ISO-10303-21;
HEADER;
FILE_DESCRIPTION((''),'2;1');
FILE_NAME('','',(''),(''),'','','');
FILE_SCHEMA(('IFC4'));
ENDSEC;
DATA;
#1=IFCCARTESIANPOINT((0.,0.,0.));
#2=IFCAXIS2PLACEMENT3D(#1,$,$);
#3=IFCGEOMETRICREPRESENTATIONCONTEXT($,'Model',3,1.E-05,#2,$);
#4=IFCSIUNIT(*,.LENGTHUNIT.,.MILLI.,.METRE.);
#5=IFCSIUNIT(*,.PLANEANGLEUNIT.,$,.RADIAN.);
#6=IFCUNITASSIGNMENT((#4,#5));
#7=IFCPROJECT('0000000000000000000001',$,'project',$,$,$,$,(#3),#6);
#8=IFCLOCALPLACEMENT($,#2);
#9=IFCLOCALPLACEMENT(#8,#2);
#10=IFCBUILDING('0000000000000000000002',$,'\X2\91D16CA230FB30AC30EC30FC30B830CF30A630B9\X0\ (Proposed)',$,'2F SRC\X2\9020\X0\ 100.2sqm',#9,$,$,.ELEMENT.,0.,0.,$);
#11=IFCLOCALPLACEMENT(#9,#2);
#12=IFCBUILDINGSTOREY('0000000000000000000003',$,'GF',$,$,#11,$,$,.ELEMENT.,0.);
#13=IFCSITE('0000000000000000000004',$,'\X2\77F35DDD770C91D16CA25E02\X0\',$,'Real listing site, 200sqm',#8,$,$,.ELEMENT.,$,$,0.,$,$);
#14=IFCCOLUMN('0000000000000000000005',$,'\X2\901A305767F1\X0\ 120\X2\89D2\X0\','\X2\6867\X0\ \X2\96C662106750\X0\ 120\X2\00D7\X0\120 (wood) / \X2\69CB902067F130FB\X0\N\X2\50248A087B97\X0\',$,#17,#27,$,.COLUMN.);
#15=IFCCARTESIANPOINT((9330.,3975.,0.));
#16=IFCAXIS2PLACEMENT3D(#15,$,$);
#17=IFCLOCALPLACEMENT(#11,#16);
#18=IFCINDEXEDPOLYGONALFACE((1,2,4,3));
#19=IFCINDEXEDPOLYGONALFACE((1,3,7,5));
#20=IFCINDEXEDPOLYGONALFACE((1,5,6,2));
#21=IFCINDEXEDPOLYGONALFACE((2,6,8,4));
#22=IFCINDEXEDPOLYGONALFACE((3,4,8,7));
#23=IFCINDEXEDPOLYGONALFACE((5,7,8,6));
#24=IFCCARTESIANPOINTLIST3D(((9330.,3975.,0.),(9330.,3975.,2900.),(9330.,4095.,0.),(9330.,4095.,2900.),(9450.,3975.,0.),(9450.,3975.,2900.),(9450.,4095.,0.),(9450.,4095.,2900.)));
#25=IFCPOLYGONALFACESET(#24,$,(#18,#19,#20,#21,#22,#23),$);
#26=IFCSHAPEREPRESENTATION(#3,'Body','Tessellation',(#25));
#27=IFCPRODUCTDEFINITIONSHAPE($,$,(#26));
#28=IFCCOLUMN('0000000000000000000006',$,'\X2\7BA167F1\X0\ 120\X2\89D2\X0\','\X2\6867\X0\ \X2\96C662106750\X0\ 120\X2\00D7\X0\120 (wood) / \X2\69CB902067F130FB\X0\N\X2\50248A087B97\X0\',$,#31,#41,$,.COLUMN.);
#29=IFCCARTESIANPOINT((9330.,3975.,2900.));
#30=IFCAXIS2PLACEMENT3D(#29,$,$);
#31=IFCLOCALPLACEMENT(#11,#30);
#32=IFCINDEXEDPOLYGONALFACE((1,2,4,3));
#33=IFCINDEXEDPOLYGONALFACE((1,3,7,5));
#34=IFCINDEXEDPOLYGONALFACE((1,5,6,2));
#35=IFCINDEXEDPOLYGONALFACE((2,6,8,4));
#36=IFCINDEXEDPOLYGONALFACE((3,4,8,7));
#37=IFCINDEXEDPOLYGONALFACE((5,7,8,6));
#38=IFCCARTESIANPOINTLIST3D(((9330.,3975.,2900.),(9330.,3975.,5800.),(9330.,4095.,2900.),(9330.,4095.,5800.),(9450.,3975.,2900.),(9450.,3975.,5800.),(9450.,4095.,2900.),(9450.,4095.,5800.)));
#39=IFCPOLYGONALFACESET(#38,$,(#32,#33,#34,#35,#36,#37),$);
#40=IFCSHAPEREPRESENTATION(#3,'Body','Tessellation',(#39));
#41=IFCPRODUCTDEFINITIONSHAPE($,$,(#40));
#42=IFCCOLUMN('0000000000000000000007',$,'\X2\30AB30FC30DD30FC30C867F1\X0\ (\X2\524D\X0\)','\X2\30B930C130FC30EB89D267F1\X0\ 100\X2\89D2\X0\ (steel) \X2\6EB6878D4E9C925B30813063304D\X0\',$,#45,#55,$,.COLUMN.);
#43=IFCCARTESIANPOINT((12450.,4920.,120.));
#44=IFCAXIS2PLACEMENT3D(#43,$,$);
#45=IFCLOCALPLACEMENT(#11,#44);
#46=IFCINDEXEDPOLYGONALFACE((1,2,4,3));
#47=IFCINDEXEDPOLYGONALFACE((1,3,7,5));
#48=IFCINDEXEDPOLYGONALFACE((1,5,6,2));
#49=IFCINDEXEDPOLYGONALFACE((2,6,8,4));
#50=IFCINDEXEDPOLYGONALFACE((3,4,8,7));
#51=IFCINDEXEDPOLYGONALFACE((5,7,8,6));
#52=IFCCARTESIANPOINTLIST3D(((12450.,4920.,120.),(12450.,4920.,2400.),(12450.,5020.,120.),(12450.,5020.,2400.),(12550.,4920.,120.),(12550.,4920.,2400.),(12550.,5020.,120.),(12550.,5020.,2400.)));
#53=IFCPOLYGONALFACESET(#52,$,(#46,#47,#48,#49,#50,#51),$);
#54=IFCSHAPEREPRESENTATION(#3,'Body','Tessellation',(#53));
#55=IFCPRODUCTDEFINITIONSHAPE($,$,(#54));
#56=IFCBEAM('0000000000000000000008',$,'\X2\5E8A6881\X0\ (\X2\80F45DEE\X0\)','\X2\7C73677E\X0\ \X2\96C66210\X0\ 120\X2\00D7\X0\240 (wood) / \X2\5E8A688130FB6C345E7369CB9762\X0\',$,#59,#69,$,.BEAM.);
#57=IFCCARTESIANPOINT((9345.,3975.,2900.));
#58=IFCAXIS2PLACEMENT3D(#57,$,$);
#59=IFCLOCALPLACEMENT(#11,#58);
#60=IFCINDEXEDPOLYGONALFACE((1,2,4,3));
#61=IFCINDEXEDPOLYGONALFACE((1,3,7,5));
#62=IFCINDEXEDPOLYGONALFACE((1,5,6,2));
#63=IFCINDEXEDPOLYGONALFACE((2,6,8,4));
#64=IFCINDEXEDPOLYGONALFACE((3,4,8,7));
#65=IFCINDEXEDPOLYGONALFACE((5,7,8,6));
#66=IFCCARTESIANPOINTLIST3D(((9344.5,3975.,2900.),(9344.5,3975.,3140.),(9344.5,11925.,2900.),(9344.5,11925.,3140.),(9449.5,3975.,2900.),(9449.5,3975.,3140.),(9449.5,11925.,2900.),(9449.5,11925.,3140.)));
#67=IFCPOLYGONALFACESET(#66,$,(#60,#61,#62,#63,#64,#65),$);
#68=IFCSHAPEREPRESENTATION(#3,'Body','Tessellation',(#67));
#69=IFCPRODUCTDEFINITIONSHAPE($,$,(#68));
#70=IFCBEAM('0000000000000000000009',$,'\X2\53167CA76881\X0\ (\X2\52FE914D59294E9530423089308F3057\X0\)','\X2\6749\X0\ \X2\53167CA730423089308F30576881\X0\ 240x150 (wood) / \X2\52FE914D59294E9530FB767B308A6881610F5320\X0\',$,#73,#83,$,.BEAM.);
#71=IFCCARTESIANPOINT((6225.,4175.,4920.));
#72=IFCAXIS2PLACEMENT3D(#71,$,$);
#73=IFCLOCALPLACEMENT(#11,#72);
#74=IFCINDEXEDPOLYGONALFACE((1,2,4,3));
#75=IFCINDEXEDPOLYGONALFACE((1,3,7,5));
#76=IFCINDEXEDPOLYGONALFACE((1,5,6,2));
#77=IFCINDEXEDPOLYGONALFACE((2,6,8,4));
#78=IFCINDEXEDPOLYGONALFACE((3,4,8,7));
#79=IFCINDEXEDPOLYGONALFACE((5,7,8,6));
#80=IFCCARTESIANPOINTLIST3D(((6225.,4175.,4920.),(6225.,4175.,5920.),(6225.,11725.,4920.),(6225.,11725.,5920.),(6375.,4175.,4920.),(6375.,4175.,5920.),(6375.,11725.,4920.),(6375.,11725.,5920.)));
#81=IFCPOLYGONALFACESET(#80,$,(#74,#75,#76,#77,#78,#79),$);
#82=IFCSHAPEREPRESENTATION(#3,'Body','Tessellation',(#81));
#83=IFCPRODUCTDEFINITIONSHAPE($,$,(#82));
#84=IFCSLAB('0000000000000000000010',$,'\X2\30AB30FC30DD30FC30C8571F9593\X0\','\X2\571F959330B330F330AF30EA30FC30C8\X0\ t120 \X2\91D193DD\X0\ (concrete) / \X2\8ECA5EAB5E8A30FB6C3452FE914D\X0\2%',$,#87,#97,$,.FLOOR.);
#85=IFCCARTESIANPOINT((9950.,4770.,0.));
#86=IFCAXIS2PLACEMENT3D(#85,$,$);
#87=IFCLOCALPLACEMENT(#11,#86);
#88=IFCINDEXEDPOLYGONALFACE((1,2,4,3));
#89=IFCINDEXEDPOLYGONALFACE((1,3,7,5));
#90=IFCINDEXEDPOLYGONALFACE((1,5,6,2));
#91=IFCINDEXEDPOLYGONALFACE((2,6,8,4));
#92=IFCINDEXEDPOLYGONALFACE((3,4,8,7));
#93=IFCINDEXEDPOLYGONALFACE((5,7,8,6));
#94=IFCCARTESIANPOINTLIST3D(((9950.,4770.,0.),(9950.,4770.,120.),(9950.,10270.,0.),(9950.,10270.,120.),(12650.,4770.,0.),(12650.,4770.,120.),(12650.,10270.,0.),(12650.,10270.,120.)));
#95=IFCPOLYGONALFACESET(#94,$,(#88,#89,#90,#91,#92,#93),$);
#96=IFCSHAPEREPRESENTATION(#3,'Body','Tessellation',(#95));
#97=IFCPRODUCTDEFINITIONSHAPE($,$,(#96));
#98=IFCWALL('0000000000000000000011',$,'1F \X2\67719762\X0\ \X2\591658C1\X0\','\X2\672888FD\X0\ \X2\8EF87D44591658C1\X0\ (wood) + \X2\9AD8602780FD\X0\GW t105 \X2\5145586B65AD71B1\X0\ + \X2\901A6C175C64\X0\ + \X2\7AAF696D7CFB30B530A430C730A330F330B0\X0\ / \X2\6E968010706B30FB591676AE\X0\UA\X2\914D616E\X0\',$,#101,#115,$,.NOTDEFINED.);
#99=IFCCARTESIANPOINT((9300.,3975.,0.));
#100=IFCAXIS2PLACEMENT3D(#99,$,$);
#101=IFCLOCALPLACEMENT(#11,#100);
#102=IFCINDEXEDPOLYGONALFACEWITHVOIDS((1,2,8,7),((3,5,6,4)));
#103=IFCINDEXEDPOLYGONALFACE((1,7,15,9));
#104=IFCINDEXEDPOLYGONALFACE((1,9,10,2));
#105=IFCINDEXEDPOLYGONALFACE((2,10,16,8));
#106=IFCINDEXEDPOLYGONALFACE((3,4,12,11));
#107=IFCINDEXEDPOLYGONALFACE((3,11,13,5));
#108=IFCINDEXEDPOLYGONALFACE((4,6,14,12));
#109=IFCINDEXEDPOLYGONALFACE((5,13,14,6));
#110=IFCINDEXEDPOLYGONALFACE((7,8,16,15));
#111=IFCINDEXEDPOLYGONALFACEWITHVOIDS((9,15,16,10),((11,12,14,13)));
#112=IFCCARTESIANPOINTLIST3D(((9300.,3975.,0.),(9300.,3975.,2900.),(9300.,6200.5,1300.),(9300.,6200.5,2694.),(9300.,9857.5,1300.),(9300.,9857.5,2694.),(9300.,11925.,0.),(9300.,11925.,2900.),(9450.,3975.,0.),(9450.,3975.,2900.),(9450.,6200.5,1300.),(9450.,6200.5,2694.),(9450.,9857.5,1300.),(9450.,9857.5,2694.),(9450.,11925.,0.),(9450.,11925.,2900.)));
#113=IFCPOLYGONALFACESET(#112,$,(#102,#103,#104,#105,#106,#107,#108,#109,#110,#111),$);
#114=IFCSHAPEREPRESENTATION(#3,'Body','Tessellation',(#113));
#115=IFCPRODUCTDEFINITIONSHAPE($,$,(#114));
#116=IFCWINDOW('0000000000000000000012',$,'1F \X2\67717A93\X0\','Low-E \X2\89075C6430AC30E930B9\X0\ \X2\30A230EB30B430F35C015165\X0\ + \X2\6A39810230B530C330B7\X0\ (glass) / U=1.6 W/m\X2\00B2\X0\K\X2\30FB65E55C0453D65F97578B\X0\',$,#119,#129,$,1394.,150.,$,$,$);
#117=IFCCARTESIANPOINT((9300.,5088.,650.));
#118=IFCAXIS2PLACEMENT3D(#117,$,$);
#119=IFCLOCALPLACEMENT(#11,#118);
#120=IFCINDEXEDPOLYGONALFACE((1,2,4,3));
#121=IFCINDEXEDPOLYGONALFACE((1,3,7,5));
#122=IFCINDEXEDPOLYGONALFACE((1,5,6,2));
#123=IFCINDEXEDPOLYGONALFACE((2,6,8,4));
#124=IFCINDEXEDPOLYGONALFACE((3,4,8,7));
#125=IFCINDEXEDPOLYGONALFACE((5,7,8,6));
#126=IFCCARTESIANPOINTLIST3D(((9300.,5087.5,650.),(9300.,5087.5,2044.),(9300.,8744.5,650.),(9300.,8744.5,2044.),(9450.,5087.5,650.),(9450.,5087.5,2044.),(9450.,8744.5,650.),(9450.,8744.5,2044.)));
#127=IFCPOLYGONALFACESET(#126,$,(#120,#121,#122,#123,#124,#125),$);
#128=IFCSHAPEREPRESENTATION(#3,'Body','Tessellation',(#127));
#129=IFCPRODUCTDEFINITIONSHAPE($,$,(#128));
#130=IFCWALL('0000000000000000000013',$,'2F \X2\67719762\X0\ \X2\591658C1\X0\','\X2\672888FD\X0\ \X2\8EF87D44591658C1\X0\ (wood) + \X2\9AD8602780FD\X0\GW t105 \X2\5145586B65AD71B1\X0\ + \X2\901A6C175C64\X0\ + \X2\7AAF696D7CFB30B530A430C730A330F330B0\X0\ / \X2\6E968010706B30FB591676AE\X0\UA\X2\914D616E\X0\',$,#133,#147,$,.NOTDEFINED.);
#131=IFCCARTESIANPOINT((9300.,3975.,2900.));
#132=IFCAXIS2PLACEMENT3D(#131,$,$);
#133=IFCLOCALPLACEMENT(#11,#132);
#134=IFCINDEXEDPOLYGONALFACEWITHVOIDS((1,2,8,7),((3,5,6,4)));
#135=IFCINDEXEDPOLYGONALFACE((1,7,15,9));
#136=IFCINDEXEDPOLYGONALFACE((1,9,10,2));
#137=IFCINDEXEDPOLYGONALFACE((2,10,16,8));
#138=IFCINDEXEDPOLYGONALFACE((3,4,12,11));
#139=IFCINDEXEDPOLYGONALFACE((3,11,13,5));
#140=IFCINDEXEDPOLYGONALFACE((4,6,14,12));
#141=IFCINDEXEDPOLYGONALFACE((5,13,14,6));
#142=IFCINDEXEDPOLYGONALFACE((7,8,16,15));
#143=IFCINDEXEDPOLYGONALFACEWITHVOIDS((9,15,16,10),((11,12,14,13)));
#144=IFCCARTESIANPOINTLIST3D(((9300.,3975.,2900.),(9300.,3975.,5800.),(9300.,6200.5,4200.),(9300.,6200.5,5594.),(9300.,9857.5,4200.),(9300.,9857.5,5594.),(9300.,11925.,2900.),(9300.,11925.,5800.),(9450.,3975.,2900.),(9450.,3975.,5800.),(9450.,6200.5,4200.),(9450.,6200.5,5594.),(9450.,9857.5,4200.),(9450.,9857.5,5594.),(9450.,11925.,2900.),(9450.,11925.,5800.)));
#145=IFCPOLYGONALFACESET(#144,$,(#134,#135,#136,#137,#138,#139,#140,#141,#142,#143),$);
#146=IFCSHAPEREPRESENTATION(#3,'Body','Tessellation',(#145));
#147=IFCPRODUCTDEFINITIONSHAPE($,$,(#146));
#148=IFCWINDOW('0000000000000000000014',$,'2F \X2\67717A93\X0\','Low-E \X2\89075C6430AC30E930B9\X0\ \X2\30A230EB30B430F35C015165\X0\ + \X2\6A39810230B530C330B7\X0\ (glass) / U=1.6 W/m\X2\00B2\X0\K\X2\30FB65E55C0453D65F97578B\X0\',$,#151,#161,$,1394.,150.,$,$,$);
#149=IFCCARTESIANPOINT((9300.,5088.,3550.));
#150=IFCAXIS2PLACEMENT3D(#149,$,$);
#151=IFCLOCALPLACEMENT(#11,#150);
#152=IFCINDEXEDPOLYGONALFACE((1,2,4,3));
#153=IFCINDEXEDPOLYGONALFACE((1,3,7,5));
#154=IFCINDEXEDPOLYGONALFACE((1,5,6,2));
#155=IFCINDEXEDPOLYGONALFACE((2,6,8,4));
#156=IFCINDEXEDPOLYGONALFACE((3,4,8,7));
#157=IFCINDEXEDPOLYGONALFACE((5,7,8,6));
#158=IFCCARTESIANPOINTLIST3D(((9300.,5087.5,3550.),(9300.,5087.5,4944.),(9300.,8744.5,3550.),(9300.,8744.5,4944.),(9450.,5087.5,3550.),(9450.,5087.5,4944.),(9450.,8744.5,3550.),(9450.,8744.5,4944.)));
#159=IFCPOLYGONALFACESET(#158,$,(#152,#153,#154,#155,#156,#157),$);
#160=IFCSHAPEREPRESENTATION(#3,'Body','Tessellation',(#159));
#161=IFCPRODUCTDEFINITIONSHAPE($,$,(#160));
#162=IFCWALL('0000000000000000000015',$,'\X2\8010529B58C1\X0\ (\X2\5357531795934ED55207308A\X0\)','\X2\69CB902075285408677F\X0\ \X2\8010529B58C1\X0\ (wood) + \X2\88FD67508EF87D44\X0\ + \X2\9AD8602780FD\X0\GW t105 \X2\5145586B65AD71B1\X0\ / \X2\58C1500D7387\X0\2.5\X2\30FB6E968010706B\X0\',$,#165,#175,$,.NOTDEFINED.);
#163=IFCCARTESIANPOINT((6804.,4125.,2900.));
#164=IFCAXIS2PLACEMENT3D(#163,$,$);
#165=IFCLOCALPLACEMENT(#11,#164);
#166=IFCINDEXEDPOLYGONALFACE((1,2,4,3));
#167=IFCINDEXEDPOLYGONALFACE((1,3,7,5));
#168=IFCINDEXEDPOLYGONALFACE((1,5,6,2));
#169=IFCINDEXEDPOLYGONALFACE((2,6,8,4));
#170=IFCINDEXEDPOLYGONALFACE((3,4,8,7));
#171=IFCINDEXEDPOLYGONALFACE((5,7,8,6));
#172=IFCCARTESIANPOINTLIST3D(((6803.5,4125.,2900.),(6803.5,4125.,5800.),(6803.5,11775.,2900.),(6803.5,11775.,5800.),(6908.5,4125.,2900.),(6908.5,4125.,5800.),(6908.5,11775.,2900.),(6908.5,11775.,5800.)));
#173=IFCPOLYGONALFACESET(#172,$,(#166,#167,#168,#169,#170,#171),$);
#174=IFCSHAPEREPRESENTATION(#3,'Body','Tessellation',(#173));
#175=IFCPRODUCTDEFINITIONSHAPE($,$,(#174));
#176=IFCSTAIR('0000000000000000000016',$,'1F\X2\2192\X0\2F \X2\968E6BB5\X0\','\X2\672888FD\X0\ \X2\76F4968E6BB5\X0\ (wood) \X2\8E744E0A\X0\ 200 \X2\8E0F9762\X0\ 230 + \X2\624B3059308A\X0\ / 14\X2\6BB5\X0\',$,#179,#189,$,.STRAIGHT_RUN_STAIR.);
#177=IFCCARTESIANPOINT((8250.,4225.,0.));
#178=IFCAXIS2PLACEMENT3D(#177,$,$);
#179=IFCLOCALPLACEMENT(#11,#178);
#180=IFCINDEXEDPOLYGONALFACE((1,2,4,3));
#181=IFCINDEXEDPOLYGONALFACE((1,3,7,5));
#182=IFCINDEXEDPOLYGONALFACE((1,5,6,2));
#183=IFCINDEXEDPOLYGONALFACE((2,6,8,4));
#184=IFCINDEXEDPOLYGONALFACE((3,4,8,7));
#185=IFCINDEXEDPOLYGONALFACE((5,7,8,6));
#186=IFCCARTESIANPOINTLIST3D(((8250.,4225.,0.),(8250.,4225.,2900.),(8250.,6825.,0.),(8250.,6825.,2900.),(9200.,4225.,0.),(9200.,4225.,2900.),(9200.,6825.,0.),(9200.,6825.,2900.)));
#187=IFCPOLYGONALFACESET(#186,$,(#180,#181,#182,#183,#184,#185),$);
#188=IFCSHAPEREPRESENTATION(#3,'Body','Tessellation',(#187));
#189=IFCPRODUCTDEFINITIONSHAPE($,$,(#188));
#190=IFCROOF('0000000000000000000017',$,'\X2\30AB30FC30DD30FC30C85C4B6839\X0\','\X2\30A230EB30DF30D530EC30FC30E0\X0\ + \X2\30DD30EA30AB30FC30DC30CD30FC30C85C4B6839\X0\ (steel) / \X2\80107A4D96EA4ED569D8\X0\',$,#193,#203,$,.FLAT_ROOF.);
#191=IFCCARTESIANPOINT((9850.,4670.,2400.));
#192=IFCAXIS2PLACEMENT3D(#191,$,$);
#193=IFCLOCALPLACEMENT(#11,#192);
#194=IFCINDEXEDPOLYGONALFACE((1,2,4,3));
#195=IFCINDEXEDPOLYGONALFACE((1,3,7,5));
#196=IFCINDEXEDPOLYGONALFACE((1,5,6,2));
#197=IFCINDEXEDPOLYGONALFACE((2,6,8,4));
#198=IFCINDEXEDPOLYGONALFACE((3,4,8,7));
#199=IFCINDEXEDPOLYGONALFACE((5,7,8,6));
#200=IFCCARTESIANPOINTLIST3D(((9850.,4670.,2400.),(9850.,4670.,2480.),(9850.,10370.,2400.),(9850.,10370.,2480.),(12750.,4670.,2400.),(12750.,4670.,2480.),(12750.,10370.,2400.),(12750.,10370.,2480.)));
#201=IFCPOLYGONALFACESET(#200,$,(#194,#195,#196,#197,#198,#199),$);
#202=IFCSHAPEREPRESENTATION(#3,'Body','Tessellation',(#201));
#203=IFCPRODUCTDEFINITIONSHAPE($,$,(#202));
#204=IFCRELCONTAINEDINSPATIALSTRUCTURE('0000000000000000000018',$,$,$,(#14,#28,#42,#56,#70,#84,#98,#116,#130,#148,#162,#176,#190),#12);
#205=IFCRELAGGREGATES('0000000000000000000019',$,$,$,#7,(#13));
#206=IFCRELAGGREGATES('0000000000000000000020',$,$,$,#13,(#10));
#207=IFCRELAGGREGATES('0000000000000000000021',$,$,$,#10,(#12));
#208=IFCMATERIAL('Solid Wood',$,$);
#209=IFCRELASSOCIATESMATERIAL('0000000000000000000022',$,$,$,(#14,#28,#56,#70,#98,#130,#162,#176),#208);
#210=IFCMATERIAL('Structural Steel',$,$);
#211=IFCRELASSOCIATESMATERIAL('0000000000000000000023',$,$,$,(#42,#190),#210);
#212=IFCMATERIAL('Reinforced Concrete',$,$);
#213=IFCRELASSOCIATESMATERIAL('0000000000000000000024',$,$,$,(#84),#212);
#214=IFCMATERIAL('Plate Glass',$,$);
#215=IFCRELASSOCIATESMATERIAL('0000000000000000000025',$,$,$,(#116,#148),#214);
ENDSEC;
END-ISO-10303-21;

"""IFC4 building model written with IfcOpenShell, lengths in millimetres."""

from ifc_helpers import new_model, si_unit, frame, frame_2d, origin, place, context, project, spatial, rectangle, extrude, material, element, fill, save


model = new_model("IFC4")

# Units and contexts
model_context = context("Model", 3, precision=1e-05, world=origin())
ifc_project = project(units=[si_unit("LENGTHUNIT", "METRE", prefix="MILLI"), si_unit("PLANEANGLEUNIT", "RADIAN")], contexts=[model_context])

# Site, building, storey
site_placement = place(None, origin())
site = spatial("IfcSite", under=ifc_project, at=site_placement, Name="石川県金沢市", ObjectType="Real listing site, 200sqm", CompositionType="ELEMENT", RefElevation=0.0)
building_placement = place(site_placement, origin())
building = spatial("IfcBuilding", under=site, at=building_placement, Name="金沢・ガレージハウス (Proposed)", ObjectType="2F SRC造 100.2sqm", CompositionType="ELEMENT", ElevationOfRefHeight=0.0, ElevationOfTerrain=0.0)
storey_placement = place(building_placement, origin())
storey = spatial("IfcBuildingStorey", under=building, at=storey_placement, Name="GF", CompositionType="ELEMENT", Elevation=0.0)

# Columns
ifc_material_1 = material(Name="Solid Wood")
column_1_placement = place(storey_placement, frame((9330.0, 3975.0, 0.0)))
element("IfcColumn", 1, at=column_1_placement, inside=storey, material=ifc_material_1, Name="通し柱 120角", Description="桧 集成材 120×120 (wood) / 構造柱・N値計算", PredefinedType="COLUMN", context=model_context, shape_type="SweptSolid", body=[
    extrude(rectangle(XDim=120.0, YDim=120.0, at=frame_2d((60.0, 60.0))), frame((9330.0, 3975.0, 0.0)), (0.0, 0.0, 1.0), 2900.0),
])
column_2_placement = place(storey_placement, frame((9330.0, 3975.0, 2900.0)))
element("IfcColumn", 2, at=column_2_placement, inside=storey, material=ifc_material_1, Name="管柱 120角", Description="桧 集成材 120×120 (wood) / 構造柱・N値計算", PredefinedType="COLUMN", context=model_context, shape_type="SweptSolid", body=[
    extrude(rectangle(XDim=120.0, YDim=120.0, at=frame_2d((60.0, 60.0))), frame((9330.0, 3975.0, 2900.0)), (0.0, 0.0, 1.0), 2900.0),
])
ifc_material_2 = material(Name="Structural Steel")
column_3_placement = place(storey_placement, frame((12450.0, 4920.0, 120.0)))
element("IfcColumn", 3, at=column_3_placement, inside=storey, material=ifc_material_2, Name="カーポート柱 (前)", Description="スチール角柱 100角 (steel) 溶融亜鉛めっき", PredefinedType="COLUMN", context=model_context, shape_type="SweptSolid", body=[
    extrude(rectangle(XDim=100.0, YDim=100.0, at=frame_2d((50.0, 50.0))), frame((12450.0, 4920.0, 120.0)), (0.0, 0.0, 1.0), 2280.0),
])

# Beams
beam_1_placement = place(storey_placement, frame((9345.0, 3975.0, 2900.0)))
element("IfcBeam", 4, at=beam_1_placement, inside=storey, material=ifc_material_1, Name="床梁 (胴差)", Description="米松 集成 120×240 (wood) / 床梁・水平構面", PredefinedType="BEAM", context=model_context, shape_type="SweptSolid", body=[
    extrude(rectangle(XDim=105.0, YDim=7950.0, at=frame_2d((52.0, 3975.0))), frame((9345.0, 3975.0, 2900.0)), (0.0, 0.0, 1.0), 240.0),
])
beam_2_placement = place(storey_placement, frame((6225.0, 4175.0, 4920.0)))
element("IfcBeam", 5, at=beam_2_placement, inside=storey, material=ifc_material_1, Name="化粧梁 (勾配天井あらわし)", Description="杉 化粧あらわし梁 240x150 (wood) / 勾配天井・登り梁意匠", PredefinedType="BEAM", context=model_context, shape_type="SweptSolid", body=[
    extrude(rectangle(XDim=150.0, YDim=7550.0, at=frame_2d((75.0, 3775.0))), frame((6225.0, 4175.0, 4920.0)), (0.0, 0.0, 1.0), 1000.0),
])

# Slab
ifc_material_3 = material(Name="Reinforced Concrete")
slab_placement = place(storey_placement, frame((9950.0, 4770.0, 0.0)))
element("IfcSlab", 6, at=slab_placement, inside=storey, material=ifc_material_3, Name="カーポート土間", Description="土間コンクリート t120 金鏝 (concrete) / 車庫床・水勾配2%", PredefinedType="FLOOR", context=model_context, shape_type="SweptSolid", body=[
    extrude(rectangle(XDim=2700.0, YDim=5500.0, at=frame_2d((1350.0, 2750.0))), frame((9950.0, 4770.0, 0.0)), (0.0, 0.0, 1.0), 120.0),
])

# Wall, opening, window
wall_1_placement = place(storey_placement, frame((9300.0, 3975.0, 0.0)))
wall_1 = element("IfcWall", 7, at=wall_1_placement, inside=storey, material=ifc_material_1, Name="1F 東面 外壁", Description="木製 軸組外壁 (wood) + 高性能GW t105 充填断熱 + 通気層 + 窯業系サイディング / 準耐火・外皮UA配慮", PredefinedType="NOTDEFINED", context=model_context, shape_type="SweptSolid", body=[
    extrude(rectangle(XDim=150.0, YDim=7950.0, at=frame_2d((75.0, 3975.0))), frame((9300.0, 3975.0, 0.0)), (0.0, 0.0, 1.0), 2900.0),
])
opening_1_placement = place(storey_placement, frame((9300.0, 5088.0, 650.0)))
opening_1 = element("IfcOpeningElement", 8, at=opening_1_placement, cuts=wall_1, PredefinedType="NOTDEFINED", context=model_context, shape_type="SweptSolid", body=[
    extrude(rectangle(XDim=150.0, YDim=3657.0, at=frame_2d((75.0, 1828.0))), frame((9300.0, 5088.0, 650.0)), (0.0, 0.0, 1.0), 1394.0),
])
ifc_material_4 = material(Name="Plate Glass")
window_1_placement = place(storey_placement, frame((9300.0, 5088.0, 650.0)))
window_1 = element("IfcWindow", 9, at=window_1_placement, inside=storey, material=ifc_material_4, Name="1F 東窓", Description="Low-E 複層ガラス アルゴン封入 + 樹脂サッシ (glass) / U=1.6 W/m²K・日射取得型", OverallHeight=1394.0, OverallWidth=150.0, context=model_context, shape_type="SweptSolid", body=[
    extrude(rectangle(XDim=150.0, YDim=3657.0, at=frame_2d((75.0, 1828.0))), frame((9300.0, 5088.0, 650.0)), (0.0, 0.0, 1.0), 1394.0),
])
fill(opening_1, window_1)

# Wall, opening, window
wall_2_placement = place(storey_placement, frame((9300.0, 3975.0, 2900.0)))
wall_2 = element("IfcWall", 10, at=wall_2_placement, inside=storey, material=ifc_material_1, Name="2F 東面 外壁", Description="木製 軸組外壁 (wood) + 高性能GW t105 充填断熱 + 通気層 + 窯業系サイディング / 準耐火・外皮UA配慮", PredefinedType="NOTDEFINED", context=model_context, shape_type="SweptSolid", body=[
    extrude(rectangle(XDim=150.0, YDim=7950.0, at=frame_2d((75.0, 3975.0))), frame((9300.0, 3975.0, 2900.0)), (0.0, 0.0, 1.0), 2900.0),
])
opening_2_placement = place(storey_placement, frame((9300.0, 5088.0, 3550.0)))
opening_2 = element("IfcOpeningElement", 11, at=opening_2_placement, cuts=wall_2, PredefinedType="NOTDEFINED", context=model_context, shape_type="SweptSolid", body=[
    extrude(rectangle(XDim=150.0, YDim=3657.0, at=frame_2d((75.0, 1828.0))), frame((9300.0, 5088.0, 3550.0)), (0.0, 0.0, 1.0), 1394.0),
])
window_2_placement = place(storey_placement, frame((9300.0, 5088.0, 3550.0)))
window_2 = element("IfcWindow", 12, at=window_2_placement, inside=storey, material=ifc_material_4, Name="2F 東窓", Description="Low-E 複層ガラス アルゴン封入 + 樹脂サッシ (glass) / U=1.6 W/m²K・日射取得型", OverallHeight=1394.0, OverallWidth=150.0, context=model_context, shape_type="SweptSolid", body=[
    extrude(rectangle(XDim=150.0, YDim=3657.0, at=frame_2d((75.0, 1828.0))), frame((9300.0, 5088.0, 3550.0)), (0.0, 0.0, 1.0), 1394.0),
])
fill(opening_2, window_2)

# Wall
wall_3_placement = place(storey_placement, frame((6804.0, 4125.0, 2900.0)))
element("IfcWall", 13, at=wall_3_placement, inside=storey, material=ifc_material_1, Name="耐力壁 (南北間仕切り)", Description="構造用合板 耐力壁 (wood) + 製材軸組 + 高性能GW t105 充填断熱 / 壁倍率2.5・準耐火", PredefinedType="NOTDEFINED", context=model_context, shape_type="SweptSolid", body=[
    extrude(rectangle(XDim=105.0, YDim=7650.0, at=frame_2d((52.0, 3825.0))), frame((6804.0, 4125.0, 2900.0)), (0.0, 0.0, 1.0), 2900.0),
])

# Stair
stair_placement = place(storey_placement, frame((8250.0, 4225.0, 0.0)))
element("IfcStair", 14, at=stair_placement, inside=storey, material=ifc_material_1, Name="1F→2F 階段", Description="木製 直階段 (wood) 蹴上 200 踏面 230 + 手すり / 14段", PredefinedType="STRAIGHT_RUN_STAIR", context=model_context, shape_type="SweptSolid", body=[
    extrude(rectangle(XDim=950.0, YDim=2600.0, at=frame_2d((475.0, 1300.0))), frame((8250.0, 4225.0, 0.0)), (0.0, 0.0, 1.0), 2900.0),
])

# Roof
roof_placement = place(storey_placement, frame((9850.0, 4670.0, 2400.0)))
element("IfcRoof", 15, at=roof_placement, inside=storey, material=ifc_material_2, Name="カーポート屋根", Description="アルミフレーム + ポリカーボネート屋根 (steel) / 耐積雪仕様", PredefinedType="FLAT_ROOF", context=model_context, shape_type="SweptSolid", body=[
    extrude(rectangle(XDim=2900.0, YDim=5700.0, at=frame_2d((1450.0, 2850.0))), frame((9850.0, 4670.0, 2400.0)), (0.0, 0.0, 1.0), 80.0),
])

save(model, "model.ifc")
